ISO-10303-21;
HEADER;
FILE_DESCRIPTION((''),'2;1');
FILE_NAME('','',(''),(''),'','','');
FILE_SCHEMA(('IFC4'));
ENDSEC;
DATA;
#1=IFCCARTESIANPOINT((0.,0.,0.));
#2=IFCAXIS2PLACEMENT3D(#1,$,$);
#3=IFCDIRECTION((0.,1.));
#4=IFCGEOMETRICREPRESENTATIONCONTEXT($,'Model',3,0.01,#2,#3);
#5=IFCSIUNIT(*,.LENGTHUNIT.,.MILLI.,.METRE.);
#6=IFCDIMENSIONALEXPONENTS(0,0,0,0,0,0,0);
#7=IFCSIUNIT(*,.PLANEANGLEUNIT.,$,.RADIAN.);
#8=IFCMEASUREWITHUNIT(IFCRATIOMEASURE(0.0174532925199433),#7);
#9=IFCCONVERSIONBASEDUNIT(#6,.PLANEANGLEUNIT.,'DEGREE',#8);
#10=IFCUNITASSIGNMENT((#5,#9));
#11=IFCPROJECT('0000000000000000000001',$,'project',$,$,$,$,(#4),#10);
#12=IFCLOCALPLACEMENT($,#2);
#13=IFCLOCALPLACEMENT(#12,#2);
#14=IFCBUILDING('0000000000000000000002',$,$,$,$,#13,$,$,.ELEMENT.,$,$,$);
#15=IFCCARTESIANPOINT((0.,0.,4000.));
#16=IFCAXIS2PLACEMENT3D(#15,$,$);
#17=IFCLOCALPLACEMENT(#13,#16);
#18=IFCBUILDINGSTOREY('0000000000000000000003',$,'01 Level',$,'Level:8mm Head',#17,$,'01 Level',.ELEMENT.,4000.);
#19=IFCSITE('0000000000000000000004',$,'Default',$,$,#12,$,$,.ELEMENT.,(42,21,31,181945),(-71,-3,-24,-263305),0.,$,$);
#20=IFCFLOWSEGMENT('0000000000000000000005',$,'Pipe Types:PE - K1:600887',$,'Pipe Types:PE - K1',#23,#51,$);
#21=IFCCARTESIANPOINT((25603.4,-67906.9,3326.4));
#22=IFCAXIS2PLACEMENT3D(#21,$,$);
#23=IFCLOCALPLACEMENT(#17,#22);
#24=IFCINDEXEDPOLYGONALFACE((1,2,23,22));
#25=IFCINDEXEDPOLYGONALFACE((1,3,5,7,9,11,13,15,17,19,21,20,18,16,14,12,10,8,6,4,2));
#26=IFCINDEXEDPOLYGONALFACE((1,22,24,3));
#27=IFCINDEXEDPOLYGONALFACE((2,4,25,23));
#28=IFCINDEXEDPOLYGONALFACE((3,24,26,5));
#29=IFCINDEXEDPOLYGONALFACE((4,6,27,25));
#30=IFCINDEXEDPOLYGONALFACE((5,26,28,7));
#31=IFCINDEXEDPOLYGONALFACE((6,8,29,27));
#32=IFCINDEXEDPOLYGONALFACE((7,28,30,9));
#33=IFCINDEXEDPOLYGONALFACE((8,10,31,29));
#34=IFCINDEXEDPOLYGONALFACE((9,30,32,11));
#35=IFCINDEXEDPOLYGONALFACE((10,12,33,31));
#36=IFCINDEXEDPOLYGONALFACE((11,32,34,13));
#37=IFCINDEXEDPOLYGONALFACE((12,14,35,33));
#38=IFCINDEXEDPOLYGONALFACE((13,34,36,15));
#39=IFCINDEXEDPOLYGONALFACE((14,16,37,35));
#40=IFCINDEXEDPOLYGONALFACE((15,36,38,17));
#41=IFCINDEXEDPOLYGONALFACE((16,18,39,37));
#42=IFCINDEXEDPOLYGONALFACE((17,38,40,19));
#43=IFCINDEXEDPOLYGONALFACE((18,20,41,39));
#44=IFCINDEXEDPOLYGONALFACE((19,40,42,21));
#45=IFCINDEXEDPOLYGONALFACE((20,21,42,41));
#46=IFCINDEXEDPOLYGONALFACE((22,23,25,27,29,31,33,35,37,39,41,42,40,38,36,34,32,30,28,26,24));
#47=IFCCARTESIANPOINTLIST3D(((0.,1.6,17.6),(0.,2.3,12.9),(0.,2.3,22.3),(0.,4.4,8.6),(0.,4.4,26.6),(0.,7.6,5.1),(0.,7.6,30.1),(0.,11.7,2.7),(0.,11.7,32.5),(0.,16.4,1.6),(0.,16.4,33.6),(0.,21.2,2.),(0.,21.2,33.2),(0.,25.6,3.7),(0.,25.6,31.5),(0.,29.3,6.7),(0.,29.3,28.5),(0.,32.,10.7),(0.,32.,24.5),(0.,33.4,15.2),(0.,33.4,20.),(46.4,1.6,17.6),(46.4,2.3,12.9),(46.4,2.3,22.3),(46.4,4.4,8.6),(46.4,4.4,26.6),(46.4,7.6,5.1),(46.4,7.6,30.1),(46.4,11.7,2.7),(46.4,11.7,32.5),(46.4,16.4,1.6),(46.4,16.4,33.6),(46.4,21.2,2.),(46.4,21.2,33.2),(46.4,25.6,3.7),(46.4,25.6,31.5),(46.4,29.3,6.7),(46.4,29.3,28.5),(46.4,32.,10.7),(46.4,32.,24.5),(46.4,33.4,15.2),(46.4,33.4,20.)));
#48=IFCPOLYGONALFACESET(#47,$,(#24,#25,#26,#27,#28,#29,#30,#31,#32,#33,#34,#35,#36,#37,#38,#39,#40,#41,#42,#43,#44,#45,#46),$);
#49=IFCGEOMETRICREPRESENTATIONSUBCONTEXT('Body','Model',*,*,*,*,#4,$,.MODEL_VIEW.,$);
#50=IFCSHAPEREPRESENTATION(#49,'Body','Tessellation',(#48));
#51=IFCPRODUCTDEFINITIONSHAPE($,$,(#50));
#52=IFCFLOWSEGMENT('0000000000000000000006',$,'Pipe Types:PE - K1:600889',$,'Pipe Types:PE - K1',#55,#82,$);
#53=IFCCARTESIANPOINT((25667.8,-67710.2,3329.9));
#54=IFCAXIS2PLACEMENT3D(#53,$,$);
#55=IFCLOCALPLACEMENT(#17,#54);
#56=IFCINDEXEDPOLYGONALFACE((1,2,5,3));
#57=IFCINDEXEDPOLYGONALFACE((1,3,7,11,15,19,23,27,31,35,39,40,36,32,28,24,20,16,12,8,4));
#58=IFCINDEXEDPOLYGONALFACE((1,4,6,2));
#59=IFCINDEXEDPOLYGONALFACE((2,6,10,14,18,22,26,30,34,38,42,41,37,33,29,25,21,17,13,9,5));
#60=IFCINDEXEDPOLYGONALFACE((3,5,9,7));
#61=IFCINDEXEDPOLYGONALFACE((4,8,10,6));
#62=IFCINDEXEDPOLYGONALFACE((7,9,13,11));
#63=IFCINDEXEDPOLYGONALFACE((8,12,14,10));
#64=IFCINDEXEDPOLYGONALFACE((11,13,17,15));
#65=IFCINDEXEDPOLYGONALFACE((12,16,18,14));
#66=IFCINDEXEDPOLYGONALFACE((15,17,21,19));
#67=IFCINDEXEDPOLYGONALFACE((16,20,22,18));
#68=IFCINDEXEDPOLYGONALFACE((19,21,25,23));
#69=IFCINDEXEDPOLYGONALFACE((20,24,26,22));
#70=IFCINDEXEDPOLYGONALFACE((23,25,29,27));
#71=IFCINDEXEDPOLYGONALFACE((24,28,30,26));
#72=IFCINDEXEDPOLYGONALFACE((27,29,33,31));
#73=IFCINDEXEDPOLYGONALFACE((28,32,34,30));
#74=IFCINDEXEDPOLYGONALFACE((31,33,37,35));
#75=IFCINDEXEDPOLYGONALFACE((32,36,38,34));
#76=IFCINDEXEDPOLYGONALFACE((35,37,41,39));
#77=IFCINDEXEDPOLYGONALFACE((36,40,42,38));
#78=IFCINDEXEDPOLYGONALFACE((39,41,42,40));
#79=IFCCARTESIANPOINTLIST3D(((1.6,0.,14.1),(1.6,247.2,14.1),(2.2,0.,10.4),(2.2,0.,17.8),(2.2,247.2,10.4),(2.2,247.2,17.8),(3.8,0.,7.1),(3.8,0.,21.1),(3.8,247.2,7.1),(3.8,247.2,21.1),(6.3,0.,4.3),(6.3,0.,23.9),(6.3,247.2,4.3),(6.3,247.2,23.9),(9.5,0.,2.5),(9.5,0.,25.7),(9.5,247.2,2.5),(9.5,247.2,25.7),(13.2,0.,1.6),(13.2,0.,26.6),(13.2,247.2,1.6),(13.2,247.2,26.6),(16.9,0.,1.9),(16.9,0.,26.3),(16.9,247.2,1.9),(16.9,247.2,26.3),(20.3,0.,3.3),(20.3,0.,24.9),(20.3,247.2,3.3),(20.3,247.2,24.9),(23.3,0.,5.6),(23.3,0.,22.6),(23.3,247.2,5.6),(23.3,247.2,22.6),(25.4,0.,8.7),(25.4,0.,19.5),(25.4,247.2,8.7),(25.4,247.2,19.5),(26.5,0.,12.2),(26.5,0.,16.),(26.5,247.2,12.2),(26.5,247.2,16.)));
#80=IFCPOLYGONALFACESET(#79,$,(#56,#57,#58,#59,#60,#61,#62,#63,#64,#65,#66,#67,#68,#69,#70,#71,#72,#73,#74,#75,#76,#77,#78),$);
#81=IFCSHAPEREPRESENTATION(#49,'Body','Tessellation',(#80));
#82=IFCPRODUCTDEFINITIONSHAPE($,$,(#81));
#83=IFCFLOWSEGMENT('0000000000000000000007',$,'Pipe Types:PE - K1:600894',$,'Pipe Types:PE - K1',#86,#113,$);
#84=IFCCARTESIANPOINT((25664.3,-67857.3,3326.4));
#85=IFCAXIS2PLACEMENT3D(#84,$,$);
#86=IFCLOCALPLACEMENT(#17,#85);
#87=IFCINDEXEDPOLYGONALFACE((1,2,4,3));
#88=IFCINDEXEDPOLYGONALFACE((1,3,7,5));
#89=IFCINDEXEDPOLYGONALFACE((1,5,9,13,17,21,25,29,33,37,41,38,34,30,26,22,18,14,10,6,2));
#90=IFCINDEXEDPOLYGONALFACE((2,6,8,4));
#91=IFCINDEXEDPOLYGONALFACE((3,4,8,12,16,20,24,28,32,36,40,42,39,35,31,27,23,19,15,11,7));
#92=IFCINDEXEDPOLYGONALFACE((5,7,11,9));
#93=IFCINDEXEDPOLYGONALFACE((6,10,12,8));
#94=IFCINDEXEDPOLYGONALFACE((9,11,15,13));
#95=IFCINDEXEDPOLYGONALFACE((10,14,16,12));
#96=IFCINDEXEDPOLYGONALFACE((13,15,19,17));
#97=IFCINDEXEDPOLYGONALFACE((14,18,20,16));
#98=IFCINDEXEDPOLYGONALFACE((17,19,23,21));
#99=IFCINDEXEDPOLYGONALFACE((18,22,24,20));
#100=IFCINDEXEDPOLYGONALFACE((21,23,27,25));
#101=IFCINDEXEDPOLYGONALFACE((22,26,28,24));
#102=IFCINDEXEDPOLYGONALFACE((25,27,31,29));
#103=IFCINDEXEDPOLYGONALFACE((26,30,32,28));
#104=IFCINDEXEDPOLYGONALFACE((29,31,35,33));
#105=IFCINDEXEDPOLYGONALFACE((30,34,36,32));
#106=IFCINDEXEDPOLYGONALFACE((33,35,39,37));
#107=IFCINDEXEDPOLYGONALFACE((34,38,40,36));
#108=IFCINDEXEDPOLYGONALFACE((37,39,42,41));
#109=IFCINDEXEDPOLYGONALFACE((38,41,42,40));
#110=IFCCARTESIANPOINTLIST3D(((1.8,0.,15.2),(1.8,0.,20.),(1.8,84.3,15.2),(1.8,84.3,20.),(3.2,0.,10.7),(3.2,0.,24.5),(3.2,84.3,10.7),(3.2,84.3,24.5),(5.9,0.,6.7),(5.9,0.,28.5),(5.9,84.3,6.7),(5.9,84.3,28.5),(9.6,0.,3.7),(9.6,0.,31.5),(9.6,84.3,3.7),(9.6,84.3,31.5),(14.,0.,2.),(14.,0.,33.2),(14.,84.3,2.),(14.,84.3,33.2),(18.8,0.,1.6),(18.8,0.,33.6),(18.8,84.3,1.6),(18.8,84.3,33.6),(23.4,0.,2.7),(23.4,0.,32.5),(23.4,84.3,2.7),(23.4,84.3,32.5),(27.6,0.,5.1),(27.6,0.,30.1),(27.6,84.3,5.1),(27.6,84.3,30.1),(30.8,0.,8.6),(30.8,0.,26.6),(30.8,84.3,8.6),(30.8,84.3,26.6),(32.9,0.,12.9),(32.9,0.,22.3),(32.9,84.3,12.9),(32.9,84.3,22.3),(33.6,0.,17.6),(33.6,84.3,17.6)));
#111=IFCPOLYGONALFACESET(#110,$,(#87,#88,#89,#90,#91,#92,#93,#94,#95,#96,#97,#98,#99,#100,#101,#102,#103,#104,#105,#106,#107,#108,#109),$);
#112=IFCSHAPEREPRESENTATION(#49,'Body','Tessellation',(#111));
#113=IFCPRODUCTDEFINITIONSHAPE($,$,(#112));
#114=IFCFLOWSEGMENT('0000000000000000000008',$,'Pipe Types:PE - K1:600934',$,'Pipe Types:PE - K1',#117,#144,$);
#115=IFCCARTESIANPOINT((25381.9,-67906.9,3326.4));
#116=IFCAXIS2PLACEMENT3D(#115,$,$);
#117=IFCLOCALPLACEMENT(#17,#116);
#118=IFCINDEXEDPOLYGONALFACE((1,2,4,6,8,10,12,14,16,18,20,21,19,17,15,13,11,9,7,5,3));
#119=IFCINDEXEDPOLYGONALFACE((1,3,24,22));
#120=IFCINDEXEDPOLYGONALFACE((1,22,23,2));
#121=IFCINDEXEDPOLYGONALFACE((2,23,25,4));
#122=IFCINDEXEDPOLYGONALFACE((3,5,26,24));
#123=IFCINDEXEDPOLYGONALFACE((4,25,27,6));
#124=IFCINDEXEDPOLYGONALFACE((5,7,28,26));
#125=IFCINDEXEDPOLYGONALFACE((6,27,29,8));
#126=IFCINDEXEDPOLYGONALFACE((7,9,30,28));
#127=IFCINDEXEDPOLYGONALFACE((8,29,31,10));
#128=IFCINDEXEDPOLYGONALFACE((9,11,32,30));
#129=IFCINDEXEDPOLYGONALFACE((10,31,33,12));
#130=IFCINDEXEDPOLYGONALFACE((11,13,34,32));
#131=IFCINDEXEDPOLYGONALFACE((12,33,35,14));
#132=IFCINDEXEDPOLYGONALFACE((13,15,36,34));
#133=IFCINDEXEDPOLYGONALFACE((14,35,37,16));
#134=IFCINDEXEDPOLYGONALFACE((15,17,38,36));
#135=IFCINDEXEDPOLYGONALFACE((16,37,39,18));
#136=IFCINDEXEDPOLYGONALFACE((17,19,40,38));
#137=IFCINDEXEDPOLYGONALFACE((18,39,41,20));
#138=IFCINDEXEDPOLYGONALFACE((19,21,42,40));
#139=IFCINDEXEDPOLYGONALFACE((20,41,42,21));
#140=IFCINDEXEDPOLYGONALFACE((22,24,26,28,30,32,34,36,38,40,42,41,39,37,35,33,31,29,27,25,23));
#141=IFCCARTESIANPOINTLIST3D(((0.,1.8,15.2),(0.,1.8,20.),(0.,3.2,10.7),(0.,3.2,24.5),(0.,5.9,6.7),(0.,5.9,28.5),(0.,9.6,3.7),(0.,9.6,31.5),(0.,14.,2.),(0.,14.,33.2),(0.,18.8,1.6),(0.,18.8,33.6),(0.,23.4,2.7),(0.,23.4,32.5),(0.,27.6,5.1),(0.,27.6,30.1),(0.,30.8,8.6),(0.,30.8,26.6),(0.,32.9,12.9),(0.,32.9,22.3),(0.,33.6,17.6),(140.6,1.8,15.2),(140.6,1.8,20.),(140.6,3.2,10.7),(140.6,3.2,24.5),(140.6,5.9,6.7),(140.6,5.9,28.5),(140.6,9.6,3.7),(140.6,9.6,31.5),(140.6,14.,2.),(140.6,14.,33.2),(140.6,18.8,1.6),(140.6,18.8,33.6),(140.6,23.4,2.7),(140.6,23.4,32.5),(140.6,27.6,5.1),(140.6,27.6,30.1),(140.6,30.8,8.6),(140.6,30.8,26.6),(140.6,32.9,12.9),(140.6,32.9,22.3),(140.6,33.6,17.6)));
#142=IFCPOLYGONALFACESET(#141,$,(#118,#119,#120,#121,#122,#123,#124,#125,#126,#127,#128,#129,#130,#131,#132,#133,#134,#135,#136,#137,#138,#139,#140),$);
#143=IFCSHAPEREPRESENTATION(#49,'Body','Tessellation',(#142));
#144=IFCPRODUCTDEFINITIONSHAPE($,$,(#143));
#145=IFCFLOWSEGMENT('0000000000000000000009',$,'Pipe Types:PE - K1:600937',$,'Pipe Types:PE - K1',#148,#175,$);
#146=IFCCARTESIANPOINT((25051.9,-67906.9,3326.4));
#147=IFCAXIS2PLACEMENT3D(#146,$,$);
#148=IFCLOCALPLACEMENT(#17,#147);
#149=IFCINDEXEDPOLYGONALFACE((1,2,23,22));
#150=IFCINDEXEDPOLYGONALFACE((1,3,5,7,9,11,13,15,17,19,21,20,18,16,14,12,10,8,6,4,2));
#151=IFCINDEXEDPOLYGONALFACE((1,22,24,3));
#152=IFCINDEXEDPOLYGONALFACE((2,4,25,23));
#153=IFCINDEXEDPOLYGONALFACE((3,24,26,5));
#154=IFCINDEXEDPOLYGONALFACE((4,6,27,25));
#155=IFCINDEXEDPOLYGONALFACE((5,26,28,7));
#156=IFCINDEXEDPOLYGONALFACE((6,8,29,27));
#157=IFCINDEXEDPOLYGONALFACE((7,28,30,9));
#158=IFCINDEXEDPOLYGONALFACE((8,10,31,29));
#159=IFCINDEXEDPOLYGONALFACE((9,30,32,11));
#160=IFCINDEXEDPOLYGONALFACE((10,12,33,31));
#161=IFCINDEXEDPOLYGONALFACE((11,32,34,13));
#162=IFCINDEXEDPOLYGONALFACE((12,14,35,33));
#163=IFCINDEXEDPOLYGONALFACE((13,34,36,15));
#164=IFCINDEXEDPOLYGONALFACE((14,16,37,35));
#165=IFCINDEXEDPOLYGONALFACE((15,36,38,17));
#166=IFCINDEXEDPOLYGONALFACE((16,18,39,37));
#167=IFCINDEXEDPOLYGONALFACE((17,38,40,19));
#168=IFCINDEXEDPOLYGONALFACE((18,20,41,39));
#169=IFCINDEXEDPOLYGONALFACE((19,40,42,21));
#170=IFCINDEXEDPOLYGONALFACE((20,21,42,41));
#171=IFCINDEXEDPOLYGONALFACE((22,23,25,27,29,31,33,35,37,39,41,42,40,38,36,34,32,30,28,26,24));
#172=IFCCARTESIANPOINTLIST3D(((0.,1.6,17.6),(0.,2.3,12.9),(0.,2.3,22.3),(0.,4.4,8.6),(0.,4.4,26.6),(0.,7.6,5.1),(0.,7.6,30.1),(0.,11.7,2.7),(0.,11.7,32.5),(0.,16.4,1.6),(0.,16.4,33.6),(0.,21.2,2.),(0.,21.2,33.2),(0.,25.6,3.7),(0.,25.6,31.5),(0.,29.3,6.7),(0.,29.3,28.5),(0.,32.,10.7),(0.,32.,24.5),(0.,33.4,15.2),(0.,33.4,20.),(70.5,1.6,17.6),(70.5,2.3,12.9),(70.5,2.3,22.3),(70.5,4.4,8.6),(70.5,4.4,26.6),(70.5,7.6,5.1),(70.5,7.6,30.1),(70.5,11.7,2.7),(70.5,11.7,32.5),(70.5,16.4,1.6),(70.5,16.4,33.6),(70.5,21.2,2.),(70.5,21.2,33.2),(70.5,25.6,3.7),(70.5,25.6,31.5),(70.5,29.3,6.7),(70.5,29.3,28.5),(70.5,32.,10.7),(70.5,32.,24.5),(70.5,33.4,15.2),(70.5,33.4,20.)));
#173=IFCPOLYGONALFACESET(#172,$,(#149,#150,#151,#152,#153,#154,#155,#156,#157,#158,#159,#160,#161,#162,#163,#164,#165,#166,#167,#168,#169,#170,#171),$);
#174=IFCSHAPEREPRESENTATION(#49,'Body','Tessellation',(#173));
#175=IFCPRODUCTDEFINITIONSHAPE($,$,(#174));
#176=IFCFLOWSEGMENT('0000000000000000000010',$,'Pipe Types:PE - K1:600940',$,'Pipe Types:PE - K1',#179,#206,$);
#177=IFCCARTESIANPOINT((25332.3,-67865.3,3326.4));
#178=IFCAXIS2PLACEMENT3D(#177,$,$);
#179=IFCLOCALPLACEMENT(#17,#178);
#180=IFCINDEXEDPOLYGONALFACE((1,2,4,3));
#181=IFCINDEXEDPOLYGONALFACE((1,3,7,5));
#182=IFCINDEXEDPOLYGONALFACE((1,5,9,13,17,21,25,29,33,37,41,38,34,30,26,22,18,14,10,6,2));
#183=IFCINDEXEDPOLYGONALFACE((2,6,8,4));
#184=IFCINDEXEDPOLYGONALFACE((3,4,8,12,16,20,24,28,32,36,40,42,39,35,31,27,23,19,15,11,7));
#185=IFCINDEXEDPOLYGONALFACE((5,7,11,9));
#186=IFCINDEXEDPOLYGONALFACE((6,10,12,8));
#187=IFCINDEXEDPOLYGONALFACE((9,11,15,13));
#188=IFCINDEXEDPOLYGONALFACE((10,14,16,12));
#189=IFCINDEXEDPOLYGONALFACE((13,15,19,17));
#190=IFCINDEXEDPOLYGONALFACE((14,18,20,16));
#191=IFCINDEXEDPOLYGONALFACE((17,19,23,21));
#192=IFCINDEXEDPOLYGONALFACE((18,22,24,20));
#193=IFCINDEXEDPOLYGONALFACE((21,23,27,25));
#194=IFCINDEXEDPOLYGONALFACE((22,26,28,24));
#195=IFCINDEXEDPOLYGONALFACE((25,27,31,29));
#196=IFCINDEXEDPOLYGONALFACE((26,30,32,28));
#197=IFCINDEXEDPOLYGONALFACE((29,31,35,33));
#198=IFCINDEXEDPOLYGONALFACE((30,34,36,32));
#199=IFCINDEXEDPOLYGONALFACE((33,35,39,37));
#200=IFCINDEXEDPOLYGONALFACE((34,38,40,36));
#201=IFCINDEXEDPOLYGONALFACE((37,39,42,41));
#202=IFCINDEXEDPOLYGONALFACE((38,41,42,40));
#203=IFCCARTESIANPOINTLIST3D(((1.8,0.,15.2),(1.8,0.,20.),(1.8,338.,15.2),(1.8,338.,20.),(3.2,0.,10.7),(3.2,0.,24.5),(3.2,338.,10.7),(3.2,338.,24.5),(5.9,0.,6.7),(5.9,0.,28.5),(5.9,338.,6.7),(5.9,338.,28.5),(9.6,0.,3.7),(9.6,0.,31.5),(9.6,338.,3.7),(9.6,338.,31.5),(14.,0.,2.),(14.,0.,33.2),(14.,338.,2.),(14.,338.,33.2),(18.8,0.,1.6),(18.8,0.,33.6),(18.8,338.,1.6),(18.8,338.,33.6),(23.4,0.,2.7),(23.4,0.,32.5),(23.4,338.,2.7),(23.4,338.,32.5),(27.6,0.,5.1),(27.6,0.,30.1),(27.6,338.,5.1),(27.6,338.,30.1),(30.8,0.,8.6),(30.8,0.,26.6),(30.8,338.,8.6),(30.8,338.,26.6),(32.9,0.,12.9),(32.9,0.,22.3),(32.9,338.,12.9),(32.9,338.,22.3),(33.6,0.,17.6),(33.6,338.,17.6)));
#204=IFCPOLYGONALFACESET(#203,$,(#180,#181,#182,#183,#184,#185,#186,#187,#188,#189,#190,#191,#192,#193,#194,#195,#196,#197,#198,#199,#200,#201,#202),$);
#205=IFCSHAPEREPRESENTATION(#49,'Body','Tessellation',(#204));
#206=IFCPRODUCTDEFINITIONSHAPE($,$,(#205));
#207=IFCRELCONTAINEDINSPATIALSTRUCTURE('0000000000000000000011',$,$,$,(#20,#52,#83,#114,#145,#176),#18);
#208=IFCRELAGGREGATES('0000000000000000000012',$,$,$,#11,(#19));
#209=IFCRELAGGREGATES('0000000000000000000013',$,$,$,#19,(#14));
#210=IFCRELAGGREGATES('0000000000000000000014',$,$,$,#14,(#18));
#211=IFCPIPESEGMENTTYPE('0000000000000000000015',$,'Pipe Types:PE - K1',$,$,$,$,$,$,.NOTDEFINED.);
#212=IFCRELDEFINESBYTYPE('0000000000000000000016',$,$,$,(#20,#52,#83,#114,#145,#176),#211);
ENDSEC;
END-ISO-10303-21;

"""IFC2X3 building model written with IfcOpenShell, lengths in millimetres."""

from ifc_helpers import new_model, entity, si_unit, converted_unit, direction, frame, frame_2d, origin, origin_2d_with_axis, place, context, subcontext, project, spatial, circle, extrude, type_object, element, save


model = new_model("IFC2X3")

# Units and contexts
model_context = context("Model", 3, precision=0.01, world=origin(), true_north=direction((0.0, 1.0)))
body_context = subcontext(model_context, "Body", "Model", "MODEL_VIEW")
ifc_project = project(units=[si_unit("LENGTHUNIT", "METRE", prefix="MILLI"), converted_unit("PLANEANGLEUNIT", "DEGREE", entity("IfcRatioMeasure", 0.0174532925199433), si_unit("PLANEANGLEUNIT", "RADIAN"), dimensions=[0, 0, 0, 0, 0, 0, 0])], contexts=[model_context])

# Site, building, storey
site_placement = place(None, origin())
site = spatial("IfcSite", under=ifc_project, at=site_placement, Name="Default", CompositionType="ELEMENT", RefLatitude=(42, 21, 31, 181945), RefLongitude=(-71, -3, -24, -263305), RefElevation=0.0)
building_placement = place(site_placement, origin())
building = spatial("IfcBuilding", under=site, at=building_placement, CompositionType="ELEMENT")
storey_placement = place(building_placement, frame((0.0, 0.0, 4000.0)))
storey = spatial("IfcBuildingStorey", under=building, at=storey_placement, Name="01 Level", ObjectType="Level:8mm Head", LongName="01 Level", CompositionType="ELEMENT", Elevation=4000.0)

# Flow segments
pipe_segment_type = type_object("IfcPipeSegmentType", Name="Pipe Types:PE - K1", PredefinedType="NOTDEFINED")
flow_segment_1_placement = place(storey_placement, frame((25603.4, -67906.9, 3326.4)))
element("IfcFlowSegment", 1, at=flow_segment_1_placement, inside=storey, type_object=pipe_segment_type, Name="Pipe Types:PE - K1:600887", ObjectType="Pipe Types:PE - K1", context=body_context, shape_type="SweptSolid", body=[
    extrude(circle(Radius=16.0, at=origin_2d_with_axis()), frame((0.0, 17.6, 17.6), z_axis=(1.0, 0.0, 0.0), x_axis=(0.0, -1.0, 0.0)), (0.0, 0.0, 1.0), 46.4),
])
flow_segment_2_placement = place(storey_placement, frame((25667.8, -67710.2, 3329.9)))
element("IfcFlowSegment", 2, at=flow_segment_2_placement, inside=storey, type_object=pipe_segment_type, Name="Pipe Types:PE - K1:600889", ObjectType="Pipe Types:PE - K1", context=body_context, shape_type="SweptSolid", body=[
    extrude(circle(Radius=12.5, at=origin_2d_with_axis()), frame((14.1, 0.0, 14.1), z_axis=(0.0, 1.0, 0.0), x_axis=(-1.0, 0.0, 0.0)), (0.0, 0.0, 1.0), 247.2),
])
flow_segment_3_placement = place(storey_placement, frame((25664.3, -67857.3, 3326.4)))
element("IfcFlowSegment", 3, at=flow_segment_3_placement, inside=storey, type_object=pipe_segment_type, Name="Pipe Types:PE - K1:600894", ObjectType="Pipe Types:PE - K1", context=body_context, shape_type="SweptSolid", body=[
    extrude(circle(Radius=16.0, at=origin_2d_with_axis()), frame((17.6, 0.0, 17.6), z_axis=(0.0, 1.0, 0.0), x_axis=(1.0, 0.0, 0.0)), (0.0, 0.0, 1.0), 84.3),
])
flow_segment_4_placement = place(storey_placement, frame((25381.9, -67906.9, 3326.4)))
element("IfcFlowSegment", 4, at=flow_segment_4_placement, inside=storey, type_object=pipe_segment_type, Name="Pipe Types:PE - K1:600934", ObjectType="Pipe Types:PE - K1", context=body_context, shape_type="SweptSolid", body=[
    extrude(circle(Radius=16.0, at=frame_2d((0.0, 0.0), x_axis=(1.0, 0.0))), frame((0.0, 17.6, 17.6), z_axis=(1.0, 0.0, 0.0), x_axis=(0.0, 1.0, 0.0)), (0.0, 0.0, 1.0), 140.6),
])
flow_segment_5_placement = place(storey_placement, frame((25051.9, -67906.9, 3326.4)))
element("IfcFlowSegment", 5, at=flow_segment_5_placement, inside=storey, type_object=pipe_segment_type, Name="Pipe Types:PE - K1:600937", ObjectType="Pipe Types:PE - K1", context=body_context, shape_type="SweptSolid", body=[
    extrude(circle(Radius=16.0, at=origin_2d_with_axis()), frame((0.0, 17.6, 17.6), z_axis=(1.0, 0.0, 0.0), x_axis=(0.0, -1.0, 0.0)), (0.0, 0.0, 1.0), 70.5),
])
flow_segment_6_placement = place(storey_placement, frame((25332.3, -67865.3, 3326.4)))
element("IfcFlowSegment", 6, at=flow_segment_6_placement, inside=storey, type_object=pipe_segment_type, Name="Pipe Types:PE - K1:600940", ObjectType="Pipe Types:PE - K1", context=body_context, shape_type="SweptSolid", body=[
    extrude(circle(Radius=16.0, at=origin_2d_with_axis()), frame((17.6, 0.0, 17.6), z_axis=(0.0, 1.0, 0.0), x_axis=(1.0, 0.0, 0.0)), (0.0, 0.0, 1.0), 338.0),
])

save(model, "model.ifc")
